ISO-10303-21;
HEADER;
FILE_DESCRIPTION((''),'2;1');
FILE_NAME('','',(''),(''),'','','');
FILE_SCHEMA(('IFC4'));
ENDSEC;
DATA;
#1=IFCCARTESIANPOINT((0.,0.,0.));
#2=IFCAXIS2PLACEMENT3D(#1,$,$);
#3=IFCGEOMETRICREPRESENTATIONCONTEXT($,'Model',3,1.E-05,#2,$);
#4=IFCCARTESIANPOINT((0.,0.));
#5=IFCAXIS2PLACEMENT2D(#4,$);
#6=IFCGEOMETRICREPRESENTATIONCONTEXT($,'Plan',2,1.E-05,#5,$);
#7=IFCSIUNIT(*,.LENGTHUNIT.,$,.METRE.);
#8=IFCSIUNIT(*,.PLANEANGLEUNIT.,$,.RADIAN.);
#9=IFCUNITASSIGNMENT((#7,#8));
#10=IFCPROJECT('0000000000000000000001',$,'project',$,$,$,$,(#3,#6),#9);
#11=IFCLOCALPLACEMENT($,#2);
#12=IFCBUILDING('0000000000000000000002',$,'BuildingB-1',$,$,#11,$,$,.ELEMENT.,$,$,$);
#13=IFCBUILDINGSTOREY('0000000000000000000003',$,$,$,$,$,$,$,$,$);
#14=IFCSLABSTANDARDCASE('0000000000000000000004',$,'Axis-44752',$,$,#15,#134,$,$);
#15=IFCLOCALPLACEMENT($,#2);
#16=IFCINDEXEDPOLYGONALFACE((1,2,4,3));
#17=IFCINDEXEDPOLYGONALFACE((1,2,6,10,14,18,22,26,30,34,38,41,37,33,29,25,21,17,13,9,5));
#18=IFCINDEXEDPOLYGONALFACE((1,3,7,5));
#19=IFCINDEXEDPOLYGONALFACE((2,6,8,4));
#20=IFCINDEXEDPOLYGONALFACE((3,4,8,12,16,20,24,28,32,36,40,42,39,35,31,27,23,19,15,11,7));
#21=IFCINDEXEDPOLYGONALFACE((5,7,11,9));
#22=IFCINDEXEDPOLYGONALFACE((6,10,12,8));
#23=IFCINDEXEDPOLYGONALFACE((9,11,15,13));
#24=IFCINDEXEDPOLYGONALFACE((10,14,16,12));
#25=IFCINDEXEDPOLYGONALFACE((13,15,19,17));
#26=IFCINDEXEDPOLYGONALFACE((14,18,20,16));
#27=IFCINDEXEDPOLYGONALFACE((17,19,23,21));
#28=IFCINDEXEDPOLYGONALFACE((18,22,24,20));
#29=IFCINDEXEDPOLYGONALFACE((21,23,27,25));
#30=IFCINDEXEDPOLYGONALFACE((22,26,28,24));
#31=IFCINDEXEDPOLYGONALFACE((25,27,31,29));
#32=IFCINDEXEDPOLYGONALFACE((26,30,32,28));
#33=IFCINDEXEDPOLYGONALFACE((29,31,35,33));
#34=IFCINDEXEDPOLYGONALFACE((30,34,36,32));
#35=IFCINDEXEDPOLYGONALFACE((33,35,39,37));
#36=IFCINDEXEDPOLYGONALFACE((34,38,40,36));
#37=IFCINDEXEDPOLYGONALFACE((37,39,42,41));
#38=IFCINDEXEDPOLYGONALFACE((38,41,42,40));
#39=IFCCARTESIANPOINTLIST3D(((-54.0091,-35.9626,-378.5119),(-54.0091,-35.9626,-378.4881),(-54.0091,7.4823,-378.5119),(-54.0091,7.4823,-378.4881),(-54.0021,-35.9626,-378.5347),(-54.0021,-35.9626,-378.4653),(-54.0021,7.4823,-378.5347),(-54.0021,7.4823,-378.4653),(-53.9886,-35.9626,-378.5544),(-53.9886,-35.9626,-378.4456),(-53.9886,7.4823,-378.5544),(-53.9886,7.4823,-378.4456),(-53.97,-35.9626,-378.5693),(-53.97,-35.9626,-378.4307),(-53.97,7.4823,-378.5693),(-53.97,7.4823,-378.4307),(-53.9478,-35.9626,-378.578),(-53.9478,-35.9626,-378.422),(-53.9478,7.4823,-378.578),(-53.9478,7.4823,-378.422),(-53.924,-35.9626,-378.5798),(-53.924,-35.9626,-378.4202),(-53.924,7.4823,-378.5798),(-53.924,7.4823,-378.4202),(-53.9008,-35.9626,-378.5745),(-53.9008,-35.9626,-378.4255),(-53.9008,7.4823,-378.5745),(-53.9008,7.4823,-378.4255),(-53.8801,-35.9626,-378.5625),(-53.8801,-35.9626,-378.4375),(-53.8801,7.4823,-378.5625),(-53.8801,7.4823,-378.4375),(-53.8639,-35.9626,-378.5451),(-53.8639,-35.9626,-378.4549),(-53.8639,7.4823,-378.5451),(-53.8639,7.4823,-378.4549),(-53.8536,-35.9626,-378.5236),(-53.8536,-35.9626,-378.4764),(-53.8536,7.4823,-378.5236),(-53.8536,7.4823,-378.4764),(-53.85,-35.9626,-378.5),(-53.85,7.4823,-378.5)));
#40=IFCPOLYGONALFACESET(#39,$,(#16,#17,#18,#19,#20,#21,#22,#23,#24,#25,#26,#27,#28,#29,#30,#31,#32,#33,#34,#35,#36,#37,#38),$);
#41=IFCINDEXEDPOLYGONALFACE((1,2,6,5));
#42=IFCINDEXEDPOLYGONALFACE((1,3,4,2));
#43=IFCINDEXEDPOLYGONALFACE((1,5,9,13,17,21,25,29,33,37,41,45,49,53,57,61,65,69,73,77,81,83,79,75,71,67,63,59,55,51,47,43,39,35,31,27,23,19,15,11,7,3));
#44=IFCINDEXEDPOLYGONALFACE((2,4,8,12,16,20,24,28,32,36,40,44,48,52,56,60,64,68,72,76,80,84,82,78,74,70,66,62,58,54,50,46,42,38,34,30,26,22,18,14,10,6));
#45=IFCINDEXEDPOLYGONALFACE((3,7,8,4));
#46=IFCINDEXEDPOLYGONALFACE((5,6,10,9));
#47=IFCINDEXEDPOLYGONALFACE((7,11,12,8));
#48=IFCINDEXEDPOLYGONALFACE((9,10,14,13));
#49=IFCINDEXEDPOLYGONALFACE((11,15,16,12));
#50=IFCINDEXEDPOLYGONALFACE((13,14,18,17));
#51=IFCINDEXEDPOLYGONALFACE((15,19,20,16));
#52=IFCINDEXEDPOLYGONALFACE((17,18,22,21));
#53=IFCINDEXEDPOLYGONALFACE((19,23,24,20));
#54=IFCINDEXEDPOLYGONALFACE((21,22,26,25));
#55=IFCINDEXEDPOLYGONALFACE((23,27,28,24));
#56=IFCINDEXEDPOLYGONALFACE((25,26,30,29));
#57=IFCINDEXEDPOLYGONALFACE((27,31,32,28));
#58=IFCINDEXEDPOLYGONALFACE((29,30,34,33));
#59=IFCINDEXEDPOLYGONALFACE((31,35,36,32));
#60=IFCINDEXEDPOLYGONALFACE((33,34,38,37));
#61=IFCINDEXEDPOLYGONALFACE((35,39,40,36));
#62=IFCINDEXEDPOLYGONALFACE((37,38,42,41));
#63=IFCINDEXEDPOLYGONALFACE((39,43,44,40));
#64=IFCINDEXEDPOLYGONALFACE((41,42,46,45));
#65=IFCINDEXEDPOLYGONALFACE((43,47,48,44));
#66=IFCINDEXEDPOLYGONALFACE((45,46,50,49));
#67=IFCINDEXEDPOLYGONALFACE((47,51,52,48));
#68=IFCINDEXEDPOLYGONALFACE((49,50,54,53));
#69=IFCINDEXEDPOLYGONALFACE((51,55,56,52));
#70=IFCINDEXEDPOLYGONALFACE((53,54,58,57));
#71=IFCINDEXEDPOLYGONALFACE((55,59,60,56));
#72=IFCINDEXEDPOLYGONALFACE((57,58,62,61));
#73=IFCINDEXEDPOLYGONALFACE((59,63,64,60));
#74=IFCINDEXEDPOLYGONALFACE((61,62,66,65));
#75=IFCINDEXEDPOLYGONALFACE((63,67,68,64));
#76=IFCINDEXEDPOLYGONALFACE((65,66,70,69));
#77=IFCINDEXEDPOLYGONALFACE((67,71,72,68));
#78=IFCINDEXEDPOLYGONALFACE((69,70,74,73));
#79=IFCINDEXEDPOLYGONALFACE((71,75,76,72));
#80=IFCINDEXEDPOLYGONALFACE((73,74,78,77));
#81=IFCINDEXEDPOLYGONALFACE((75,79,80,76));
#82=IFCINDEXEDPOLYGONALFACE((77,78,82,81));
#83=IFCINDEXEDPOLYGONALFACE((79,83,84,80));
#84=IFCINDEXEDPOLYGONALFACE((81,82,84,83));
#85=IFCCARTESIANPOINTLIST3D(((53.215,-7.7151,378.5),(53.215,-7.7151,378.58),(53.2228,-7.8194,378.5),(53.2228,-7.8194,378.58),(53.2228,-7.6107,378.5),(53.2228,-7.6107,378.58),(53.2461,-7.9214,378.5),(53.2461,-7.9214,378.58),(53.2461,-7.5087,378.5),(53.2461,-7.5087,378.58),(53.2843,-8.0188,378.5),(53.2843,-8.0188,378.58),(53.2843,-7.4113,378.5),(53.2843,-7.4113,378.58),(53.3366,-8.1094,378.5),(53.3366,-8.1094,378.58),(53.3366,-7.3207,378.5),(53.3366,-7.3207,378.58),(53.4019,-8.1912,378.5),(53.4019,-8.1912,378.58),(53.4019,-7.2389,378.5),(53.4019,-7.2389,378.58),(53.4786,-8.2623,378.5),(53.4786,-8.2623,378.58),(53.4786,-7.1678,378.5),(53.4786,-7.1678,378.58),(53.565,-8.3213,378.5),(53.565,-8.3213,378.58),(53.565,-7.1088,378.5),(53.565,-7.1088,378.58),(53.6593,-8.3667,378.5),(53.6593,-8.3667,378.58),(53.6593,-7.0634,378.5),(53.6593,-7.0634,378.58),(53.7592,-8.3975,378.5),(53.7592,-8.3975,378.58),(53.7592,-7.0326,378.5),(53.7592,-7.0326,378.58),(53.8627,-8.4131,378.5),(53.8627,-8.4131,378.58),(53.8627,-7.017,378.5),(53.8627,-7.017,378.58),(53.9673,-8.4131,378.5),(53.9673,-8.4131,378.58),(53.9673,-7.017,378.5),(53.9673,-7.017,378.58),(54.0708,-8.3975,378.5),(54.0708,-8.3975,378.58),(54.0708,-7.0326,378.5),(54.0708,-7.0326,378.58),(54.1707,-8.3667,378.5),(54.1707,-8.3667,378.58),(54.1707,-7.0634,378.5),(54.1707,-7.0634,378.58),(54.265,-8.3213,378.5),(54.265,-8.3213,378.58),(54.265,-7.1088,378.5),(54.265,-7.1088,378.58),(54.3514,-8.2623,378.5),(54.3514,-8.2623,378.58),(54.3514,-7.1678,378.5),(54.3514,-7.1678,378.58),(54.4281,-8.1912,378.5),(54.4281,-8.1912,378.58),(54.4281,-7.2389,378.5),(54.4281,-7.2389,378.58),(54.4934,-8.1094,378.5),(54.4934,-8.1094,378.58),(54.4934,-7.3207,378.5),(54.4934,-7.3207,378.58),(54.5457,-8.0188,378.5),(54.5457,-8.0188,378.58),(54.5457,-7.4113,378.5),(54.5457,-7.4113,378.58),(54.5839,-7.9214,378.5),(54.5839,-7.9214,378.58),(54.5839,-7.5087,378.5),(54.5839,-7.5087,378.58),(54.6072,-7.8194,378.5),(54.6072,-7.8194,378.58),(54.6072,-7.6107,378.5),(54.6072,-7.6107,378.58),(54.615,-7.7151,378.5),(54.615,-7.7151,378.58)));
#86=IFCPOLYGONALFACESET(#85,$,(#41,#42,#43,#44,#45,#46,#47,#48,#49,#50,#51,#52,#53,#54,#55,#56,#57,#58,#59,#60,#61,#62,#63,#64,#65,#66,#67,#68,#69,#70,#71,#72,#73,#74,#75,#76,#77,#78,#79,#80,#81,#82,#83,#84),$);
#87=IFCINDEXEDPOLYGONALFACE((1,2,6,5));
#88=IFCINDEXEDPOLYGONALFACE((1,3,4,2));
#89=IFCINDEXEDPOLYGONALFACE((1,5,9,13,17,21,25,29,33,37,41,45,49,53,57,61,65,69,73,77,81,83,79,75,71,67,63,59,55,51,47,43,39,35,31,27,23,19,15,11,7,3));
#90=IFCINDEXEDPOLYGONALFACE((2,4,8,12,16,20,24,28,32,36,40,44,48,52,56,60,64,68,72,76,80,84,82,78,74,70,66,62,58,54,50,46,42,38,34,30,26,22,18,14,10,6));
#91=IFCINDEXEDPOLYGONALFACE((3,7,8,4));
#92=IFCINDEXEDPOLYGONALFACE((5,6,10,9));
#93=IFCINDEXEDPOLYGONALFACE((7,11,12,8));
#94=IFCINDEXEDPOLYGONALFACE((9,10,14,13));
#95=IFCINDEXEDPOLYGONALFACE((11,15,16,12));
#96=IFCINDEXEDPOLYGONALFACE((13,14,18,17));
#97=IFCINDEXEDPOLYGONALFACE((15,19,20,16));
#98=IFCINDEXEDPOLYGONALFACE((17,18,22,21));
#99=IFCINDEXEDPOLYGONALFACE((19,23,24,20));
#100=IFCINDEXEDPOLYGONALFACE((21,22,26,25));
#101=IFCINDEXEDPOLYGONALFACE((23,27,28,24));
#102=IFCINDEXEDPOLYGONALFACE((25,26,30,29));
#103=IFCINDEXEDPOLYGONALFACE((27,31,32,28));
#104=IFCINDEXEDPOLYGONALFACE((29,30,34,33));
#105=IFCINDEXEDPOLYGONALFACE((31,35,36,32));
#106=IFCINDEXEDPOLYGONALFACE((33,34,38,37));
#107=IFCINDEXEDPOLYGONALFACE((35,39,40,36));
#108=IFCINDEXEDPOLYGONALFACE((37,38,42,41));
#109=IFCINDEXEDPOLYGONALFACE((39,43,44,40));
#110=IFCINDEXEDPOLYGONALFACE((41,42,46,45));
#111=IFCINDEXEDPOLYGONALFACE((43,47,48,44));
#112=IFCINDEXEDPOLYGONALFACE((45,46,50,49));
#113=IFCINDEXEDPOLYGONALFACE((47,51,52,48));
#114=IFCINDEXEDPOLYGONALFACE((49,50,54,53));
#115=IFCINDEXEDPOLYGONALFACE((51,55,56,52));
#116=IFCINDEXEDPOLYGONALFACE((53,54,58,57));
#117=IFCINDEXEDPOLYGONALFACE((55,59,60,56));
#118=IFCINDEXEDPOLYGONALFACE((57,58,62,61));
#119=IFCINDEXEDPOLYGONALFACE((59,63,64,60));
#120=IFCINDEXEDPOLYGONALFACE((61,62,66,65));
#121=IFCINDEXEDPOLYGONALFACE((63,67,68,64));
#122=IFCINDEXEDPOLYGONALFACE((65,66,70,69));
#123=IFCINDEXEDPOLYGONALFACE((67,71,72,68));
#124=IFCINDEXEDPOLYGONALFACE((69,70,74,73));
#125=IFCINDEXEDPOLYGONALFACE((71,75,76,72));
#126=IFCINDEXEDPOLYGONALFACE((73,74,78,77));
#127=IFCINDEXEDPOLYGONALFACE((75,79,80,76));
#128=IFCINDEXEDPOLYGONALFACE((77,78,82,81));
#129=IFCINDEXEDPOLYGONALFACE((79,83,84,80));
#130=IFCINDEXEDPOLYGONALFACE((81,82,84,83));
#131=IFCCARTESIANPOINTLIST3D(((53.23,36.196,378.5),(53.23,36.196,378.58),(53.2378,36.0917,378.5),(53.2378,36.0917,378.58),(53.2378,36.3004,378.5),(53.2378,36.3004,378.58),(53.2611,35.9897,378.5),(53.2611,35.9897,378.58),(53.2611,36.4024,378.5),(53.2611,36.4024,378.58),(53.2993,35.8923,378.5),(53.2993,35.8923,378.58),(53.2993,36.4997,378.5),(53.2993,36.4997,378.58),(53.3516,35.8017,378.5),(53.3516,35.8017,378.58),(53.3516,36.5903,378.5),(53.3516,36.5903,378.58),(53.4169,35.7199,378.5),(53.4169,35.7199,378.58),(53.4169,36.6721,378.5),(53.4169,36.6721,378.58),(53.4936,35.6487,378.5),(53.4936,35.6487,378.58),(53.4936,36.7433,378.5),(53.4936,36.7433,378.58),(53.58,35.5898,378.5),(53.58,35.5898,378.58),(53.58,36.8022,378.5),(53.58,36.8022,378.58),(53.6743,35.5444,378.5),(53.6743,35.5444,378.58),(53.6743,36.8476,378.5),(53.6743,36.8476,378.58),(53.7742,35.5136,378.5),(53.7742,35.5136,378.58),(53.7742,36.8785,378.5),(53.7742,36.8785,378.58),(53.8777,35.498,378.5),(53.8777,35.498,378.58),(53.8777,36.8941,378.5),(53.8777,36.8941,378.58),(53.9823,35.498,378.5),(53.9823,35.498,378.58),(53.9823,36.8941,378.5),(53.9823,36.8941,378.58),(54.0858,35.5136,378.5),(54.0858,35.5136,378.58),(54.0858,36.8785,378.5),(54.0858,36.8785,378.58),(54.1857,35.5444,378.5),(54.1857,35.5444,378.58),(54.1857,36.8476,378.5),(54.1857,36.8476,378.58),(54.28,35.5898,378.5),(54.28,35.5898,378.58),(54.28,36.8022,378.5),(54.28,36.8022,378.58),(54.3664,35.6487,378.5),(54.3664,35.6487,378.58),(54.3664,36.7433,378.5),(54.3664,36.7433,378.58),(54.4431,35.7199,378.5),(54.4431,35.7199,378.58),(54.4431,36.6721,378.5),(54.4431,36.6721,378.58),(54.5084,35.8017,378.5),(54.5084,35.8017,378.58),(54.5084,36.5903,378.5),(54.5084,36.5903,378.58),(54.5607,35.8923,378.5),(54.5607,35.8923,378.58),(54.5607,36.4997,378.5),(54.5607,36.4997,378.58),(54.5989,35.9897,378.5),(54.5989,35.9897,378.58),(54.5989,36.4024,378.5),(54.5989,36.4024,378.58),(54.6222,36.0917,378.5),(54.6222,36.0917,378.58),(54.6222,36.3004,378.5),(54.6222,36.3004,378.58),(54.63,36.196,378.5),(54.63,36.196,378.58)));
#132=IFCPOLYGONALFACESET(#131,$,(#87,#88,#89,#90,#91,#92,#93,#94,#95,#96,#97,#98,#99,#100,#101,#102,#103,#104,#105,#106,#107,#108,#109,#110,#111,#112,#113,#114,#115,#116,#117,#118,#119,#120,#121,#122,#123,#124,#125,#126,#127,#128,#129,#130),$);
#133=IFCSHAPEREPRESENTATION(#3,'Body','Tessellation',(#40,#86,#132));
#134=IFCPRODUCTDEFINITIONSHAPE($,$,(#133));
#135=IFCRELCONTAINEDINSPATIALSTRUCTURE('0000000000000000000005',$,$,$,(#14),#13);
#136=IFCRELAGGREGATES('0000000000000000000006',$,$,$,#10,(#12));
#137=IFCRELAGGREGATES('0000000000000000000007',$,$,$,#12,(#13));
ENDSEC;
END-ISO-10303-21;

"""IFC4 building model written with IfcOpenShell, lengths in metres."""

from ifc_helpers import new_model, entity, si_unit, frame, origin, origin_2d, place, context, project, spatial, circle, extrude, element, save


model = new_model("IFC4")

# Units and contexts
model_context = context("Model", 3, precision=1e-05, world=origin())
plan_context = context("Plan", 2, precision=1e-05, world=origin_2d())
ifc_project = project(units=[si_unit("LENGTHUNIT", "METRE"), si_unit("PLANEANGLEUNIT", "RADIAN")], contexts=[model_context, plan_context])

# Building, storey
building_placement = place(None, origin())
building = spatial("IfcBuilding", under=ifc_project, at=building_placement, Name="BuildingB-1", CompositionType="ELEMENT")
storey = spatial("IfcBuildingStorey", under=building)

# Slab
element("IfcSlabStandardCase", 1, inside=storey, Name="Axis-44752", context=model_context, shape_type="AdvancedSweptSolid", body=[
    entity("IfcSurfaceCurveSweptAreaSolid", entity("IfcCircleProfileDef", "AREA", None, None, 0.08), None, entity("IfcPolyline", [entity("IfcCartesianPoint", [53.93, -7.4823, 378.5]), entity("IfcCartesianPoint", [53.93, 35.9626, 378.5])]), None, None, entity("IfcPlane", entity("IfcAxis2Placement3D", entity("IfcCartesianPoint", [53.93, -7.4823, 378.5]), entity("IfcDirection", [0.0, 0.0, 1.0]), entity("IfcDirection", [1.0, 0.0, 0.0])))),
    extrude(circle(Radius=0.7), frame((53.915, -7.7151, 378.5)), (0.0, 0.0, 1.0), 0.08),
    extrude(circle(Radius=0.7), frame((53.93, 36.196, 378.5)), (0.0, 0.0, 1.0), 0.08),
])

save(model, "model.ifc")
